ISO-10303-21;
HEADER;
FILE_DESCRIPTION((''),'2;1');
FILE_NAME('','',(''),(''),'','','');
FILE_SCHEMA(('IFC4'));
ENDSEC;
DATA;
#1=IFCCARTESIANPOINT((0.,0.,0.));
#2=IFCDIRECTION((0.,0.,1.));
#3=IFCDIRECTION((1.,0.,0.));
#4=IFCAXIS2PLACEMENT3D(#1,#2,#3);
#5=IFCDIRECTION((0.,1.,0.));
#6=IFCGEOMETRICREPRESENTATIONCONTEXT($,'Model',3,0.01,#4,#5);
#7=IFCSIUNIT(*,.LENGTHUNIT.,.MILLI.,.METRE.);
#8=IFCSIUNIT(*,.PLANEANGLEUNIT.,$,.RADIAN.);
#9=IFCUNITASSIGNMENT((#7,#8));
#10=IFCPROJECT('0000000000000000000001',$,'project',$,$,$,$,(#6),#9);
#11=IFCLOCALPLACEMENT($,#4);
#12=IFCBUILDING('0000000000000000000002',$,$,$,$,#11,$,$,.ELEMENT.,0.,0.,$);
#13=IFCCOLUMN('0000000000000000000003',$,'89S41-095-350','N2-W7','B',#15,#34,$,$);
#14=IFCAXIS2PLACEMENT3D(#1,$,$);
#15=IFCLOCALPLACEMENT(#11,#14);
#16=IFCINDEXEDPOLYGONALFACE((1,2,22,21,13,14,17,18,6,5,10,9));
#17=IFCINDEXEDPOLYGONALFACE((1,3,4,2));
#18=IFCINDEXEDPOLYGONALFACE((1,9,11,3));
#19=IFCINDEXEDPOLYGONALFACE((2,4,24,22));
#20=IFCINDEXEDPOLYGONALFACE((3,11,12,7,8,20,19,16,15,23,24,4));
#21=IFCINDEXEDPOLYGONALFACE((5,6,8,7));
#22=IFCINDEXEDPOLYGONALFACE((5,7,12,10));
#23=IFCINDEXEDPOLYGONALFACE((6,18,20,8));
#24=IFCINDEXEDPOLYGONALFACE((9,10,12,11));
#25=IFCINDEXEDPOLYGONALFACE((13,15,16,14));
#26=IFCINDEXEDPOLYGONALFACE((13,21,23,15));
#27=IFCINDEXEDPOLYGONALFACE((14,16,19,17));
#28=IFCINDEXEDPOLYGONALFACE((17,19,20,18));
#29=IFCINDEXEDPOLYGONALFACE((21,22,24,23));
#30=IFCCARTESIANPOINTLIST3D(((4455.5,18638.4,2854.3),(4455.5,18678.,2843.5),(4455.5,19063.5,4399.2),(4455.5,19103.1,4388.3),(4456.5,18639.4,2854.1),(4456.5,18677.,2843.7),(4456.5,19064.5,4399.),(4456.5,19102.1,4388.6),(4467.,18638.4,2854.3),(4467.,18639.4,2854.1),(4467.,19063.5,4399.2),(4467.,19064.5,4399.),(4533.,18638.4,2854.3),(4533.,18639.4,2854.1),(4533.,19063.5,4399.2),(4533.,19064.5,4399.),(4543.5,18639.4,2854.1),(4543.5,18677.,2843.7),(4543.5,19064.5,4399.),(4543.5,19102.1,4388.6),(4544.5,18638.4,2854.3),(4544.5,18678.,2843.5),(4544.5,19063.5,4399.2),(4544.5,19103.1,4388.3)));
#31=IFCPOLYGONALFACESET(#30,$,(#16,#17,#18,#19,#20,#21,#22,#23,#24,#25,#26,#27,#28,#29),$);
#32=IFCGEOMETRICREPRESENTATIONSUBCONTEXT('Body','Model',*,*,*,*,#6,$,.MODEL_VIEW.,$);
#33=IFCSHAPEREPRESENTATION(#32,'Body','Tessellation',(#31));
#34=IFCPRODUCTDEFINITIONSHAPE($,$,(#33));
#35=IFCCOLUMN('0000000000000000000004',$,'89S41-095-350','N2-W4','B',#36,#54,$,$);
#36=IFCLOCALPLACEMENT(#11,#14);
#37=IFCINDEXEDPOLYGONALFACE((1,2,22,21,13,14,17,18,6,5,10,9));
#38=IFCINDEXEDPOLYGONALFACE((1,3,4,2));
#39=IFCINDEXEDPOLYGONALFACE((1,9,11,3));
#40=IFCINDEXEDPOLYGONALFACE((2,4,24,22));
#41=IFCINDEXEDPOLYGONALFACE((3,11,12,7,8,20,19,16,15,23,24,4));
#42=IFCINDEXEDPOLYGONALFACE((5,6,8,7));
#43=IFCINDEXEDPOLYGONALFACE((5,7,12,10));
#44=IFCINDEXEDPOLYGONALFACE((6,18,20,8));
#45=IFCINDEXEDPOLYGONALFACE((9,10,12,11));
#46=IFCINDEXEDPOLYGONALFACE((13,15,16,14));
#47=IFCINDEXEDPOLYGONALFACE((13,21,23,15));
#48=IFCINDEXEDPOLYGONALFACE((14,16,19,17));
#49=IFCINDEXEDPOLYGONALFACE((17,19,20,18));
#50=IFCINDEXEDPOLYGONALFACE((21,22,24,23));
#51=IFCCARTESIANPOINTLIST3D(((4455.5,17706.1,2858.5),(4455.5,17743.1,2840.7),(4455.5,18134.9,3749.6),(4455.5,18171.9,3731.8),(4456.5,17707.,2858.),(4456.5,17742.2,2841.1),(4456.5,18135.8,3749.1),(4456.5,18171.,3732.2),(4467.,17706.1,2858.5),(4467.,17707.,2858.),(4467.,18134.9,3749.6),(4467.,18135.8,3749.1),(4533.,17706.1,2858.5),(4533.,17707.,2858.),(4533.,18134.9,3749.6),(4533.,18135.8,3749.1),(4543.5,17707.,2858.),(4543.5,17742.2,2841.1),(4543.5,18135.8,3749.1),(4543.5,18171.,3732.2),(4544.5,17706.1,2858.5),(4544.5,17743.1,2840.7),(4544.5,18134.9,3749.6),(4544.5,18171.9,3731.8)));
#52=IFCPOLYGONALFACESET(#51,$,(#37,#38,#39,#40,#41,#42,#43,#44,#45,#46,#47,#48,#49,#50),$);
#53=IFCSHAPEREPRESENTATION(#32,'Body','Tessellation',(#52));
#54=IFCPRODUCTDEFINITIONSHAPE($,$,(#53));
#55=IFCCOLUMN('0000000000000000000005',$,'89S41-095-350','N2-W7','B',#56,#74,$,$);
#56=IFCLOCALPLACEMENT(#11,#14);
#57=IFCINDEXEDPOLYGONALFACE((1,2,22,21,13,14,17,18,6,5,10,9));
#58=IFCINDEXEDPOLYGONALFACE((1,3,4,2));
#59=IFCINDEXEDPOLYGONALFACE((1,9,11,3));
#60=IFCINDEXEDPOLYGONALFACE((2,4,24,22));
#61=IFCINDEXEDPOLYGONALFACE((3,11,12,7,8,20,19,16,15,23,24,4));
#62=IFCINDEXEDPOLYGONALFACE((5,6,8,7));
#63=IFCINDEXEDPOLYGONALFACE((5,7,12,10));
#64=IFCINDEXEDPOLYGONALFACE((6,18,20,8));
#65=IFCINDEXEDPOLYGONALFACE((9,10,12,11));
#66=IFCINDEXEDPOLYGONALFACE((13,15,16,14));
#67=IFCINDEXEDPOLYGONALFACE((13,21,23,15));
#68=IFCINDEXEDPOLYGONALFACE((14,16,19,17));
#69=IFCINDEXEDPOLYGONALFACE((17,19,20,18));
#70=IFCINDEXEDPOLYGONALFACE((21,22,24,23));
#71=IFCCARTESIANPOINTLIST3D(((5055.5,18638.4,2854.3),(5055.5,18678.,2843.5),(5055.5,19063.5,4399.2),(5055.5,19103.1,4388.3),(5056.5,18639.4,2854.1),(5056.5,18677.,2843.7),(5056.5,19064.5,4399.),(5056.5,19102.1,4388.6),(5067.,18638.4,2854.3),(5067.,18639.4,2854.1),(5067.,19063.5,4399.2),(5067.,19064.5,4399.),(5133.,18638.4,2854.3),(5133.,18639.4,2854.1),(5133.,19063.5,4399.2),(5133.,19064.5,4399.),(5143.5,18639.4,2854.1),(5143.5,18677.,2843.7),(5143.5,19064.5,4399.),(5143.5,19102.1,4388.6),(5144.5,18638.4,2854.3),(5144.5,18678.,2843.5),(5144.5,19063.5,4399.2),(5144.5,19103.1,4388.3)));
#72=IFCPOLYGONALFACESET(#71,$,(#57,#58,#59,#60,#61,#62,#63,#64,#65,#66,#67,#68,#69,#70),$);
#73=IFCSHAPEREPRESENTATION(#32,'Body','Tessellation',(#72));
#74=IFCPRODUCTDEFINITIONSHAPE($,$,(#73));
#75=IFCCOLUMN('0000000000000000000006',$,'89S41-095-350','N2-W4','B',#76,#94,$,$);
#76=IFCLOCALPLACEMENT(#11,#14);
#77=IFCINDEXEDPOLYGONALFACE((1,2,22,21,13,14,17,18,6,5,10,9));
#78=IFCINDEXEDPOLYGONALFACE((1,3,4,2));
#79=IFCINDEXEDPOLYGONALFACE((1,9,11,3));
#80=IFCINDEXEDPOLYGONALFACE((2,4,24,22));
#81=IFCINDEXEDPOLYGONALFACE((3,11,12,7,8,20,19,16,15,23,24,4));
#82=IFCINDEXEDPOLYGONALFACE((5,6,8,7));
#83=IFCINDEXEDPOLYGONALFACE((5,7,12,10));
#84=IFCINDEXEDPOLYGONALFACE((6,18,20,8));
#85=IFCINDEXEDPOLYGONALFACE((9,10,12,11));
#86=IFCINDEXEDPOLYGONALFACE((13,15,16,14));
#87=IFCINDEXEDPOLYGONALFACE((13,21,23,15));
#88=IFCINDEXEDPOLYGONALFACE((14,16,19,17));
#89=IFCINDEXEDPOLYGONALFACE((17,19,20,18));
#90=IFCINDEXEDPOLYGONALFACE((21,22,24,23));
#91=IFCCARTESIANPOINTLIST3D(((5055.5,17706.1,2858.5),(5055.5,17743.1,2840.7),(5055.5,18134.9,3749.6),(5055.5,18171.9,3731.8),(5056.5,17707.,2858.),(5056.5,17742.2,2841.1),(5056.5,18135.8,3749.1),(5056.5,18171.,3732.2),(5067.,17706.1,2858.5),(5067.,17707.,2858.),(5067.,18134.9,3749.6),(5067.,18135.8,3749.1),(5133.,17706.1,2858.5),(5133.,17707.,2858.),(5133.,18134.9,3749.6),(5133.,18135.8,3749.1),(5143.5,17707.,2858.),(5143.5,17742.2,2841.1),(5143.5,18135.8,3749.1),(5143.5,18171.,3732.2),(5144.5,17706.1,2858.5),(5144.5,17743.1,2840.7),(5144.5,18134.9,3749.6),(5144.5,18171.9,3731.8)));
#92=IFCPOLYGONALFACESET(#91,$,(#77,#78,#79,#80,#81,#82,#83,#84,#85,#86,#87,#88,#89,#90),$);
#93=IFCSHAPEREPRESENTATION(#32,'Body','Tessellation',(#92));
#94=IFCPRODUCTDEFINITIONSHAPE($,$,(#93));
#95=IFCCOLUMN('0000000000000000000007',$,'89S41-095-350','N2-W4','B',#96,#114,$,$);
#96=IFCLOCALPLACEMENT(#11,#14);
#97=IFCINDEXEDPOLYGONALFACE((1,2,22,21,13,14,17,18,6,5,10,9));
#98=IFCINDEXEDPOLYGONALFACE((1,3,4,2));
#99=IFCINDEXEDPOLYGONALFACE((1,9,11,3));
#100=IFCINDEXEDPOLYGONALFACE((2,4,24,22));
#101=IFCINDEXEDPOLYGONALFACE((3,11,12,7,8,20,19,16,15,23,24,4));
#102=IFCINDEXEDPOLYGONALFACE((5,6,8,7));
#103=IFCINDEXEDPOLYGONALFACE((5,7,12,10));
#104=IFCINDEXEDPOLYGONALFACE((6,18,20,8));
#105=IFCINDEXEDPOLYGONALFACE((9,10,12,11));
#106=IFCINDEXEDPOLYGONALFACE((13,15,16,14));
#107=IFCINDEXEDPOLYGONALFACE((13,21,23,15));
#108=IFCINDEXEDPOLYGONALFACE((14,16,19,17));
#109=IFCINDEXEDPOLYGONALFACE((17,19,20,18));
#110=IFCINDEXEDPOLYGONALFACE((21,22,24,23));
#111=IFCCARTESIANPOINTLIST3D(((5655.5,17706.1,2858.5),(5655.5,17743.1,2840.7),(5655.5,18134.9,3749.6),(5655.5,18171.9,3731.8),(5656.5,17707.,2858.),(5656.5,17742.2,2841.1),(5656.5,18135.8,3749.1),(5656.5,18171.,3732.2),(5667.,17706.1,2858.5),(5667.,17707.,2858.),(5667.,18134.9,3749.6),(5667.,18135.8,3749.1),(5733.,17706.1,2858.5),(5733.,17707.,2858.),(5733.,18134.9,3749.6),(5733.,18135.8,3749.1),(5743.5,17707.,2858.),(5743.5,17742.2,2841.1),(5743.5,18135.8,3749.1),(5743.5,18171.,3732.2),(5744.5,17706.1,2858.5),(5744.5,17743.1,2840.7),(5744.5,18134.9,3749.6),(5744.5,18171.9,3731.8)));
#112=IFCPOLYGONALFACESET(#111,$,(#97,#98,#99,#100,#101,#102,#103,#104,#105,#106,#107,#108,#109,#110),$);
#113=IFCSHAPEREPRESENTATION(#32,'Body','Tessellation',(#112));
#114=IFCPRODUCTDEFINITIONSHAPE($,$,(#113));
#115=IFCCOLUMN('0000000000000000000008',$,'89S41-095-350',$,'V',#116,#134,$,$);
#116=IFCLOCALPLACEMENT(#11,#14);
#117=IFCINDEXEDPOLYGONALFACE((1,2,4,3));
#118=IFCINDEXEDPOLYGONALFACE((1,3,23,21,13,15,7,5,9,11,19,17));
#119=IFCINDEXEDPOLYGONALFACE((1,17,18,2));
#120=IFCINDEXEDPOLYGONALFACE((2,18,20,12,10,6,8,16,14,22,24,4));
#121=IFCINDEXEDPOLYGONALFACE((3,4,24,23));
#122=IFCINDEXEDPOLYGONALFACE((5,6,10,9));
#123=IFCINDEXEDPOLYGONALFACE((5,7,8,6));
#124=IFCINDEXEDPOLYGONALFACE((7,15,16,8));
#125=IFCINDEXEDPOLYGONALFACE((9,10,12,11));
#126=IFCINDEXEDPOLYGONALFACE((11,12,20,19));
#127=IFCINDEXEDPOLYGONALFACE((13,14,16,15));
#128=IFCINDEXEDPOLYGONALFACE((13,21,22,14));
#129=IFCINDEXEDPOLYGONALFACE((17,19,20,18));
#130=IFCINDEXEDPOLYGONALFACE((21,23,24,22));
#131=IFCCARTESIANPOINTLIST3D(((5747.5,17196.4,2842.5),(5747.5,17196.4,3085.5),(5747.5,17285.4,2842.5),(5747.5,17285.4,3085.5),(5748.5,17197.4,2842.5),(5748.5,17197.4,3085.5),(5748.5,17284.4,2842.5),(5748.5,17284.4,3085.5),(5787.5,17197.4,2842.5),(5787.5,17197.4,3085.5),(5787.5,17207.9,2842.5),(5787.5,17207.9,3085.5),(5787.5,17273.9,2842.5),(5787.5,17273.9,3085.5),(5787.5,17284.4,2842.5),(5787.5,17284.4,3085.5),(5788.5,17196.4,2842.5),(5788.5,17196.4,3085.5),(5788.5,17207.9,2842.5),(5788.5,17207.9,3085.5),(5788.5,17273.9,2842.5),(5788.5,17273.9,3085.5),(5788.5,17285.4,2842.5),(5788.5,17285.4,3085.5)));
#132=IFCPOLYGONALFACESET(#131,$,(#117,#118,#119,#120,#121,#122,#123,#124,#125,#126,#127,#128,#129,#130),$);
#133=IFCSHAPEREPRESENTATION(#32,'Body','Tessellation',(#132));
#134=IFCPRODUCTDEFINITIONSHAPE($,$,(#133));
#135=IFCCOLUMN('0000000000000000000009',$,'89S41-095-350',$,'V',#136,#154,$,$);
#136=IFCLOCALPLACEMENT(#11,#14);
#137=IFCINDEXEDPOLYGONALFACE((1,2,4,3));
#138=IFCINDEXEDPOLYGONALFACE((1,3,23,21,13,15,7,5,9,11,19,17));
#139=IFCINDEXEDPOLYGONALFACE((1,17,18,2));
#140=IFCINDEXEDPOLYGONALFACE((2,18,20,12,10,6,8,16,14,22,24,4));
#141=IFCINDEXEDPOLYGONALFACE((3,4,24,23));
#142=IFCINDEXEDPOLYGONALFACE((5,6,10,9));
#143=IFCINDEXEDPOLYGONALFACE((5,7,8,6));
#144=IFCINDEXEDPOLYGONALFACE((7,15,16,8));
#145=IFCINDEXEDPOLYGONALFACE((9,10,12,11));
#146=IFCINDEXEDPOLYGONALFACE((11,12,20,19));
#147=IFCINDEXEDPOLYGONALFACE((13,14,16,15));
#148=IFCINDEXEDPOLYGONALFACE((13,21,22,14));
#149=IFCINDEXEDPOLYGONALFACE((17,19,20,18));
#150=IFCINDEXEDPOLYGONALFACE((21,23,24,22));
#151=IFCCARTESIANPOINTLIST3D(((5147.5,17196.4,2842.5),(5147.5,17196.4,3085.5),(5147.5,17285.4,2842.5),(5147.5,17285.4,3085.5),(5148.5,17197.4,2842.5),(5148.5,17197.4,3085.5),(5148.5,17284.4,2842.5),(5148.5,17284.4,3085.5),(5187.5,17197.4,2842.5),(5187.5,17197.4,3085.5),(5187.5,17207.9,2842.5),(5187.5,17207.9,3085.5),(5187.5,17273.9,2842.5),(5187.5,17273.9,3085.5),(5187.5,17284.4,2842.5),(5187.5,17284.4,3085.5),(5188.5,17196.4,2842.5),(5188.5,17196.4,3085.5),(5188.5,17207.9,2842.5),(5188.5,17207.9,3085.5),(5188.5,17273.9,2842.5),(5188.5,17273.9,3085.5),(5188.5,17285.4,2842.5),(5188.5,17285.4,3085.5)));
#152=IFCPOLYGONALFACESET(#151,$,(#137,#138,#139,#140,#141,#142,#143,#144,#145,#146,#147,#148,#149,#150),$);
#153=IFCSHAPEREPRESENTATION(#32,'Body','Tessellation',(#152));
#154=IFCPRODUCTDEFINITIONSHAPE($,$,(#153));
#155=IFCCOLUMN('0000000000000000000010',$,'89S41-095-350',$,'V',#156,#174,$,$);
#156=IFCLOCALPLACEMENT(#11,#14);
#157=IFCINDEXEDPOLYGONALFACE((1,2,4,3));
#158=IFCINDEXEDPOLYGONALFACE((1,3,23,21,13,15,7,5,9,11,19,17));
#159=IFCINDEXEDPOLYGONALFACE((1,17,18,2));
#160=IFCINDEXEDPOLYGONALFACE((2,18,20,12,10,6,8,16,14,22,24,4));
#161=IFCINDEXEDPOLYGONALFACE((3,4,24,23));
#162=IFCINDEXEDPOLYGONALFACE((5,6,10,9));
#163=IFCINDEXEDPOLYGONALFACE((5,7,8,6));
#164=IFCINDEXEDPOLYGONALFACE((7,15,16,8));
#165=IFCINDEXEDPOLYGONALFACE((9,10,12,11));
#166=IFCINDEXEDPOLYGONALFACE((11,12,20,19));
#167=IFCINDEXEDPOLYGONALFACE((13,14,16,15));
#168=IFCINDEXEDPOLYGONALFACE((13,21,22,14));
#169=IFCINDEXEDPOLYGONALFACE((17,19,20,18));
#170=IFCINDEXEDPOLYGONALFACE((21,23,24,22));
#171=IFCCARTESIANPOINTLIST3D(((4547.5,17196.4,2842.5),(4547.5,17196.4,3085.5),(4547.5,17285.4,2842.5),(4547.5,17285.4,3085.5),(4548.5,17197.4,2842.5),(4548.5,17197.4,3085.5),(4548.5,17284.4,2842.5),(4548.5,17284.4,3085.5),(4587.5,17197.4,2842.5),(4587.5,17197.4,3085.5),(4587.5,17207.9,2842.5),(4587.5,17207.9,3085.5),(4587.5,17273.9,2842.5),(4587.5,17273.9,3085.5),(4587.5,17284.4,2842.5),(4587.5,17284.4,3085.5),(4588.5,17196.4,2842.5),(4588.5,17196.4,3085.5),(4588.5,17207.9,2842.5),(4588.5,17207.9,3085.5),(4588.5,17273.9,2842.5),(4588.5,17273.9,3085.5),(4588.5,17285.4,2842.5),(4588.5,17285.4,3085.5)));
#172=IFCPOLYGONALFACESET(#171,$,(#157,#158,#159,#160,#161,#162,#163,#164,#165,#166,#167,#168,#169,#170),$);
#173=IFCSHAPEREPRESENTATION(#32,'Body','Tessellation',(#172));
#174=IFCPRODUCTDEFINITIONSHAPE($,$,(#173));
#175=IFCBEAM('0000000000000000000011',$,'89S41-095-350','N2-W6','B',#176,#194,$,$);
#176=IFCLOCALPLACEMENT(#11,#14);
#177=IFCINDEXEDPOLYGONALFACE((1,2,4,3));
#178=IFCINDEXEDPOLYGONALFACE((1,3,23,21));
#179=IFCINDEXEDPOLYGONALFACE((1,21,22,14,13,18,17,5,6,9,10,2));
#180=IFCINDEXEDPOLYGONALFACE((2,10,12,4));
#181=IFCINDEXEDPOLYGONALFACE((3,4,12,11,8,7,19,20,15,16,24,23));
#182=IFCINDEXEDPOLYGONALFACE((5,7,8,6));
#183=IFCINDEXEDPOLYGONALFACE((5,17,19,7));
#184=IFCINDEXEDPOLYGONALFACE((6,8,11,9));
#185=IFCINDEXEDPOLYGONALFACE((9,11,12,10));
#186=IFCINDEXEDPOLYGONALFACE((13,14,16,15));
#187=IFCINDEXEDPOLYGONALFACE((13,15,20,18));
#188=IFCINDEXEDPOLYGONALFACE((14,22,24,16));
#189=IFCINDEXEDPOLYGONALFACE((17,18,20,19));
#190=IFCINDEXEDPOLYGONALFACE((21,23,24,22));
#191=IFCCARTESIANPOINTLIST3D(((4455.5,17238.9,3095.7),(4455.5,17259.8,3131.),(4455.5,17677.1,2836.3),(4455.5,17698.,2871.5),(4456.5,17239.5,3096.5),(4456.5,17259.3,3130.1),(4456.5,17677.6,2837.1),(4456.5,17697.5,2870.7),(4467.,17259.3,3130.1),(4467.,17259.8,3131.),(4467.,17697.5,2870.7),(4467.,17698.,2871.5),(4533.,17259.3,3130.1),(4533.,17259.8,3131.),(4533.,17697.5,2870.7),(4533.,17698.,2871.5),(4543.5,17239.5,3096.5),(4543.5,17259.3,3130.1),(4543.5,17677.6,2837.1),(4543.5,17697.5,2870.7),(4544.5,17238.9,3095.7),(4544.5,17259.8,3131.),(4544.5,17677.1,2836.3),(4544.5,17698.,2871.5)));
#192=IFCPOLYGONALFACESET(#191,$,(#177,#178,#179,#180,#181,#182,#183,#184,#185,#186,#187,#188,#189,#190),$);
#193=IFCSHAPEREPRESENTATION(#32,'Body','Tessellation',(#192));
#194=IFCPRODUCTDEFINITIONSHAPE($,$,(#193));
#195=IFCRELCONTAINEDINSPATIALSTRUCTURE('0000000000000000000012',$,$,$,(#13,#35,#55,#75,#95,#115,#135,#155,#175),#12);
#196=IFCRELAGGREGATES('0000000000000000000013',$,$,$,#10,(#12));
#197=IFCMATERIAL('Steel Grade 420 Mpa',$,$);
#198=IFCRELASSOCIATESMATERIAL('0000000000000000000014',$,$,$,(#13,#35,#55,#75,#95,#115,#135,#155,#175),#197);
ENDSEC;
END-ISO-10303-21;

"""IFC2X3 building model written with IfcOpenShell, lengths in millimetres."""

from ifc_helpers import new_model, si_unit, direction, frame, origin, origin_with_axes, origin_2d_with_axis, place, context, subcontext, project, spatial, c_section, extrude, source, transform, mapped, material, element, save


model = new_model("IFC2X3")

# Units and contexts
model_context = context("Model", 3, precision=0.01, world=origin_with_axes(), true_north=direction((0.0, 1.0, 0.0)))
body_context = subcontext(model_context, "Body", "Model", "MODEL_VIEW")
ifc_project = project(units=[si_unit("LENGTHUNIT", "METRE", prefix="MILLI"), si_unit("PLANEANGLEUNIT", "RADIAN")], contexts=[model_context])

# Building
building_placement = place(None, origin_with_axes())
building = spatial("IfcBuilding", under=ifc_project, at=building_placement, CompositionType="ELEMENT", ElevationOfRefHeight=0.0, ElevationOfTerrain=0.0)

# Columns
ifc_material = material(Name="Steel Grade 420 Mpa")
shared_shape_1 = source(origin(), body_context, "Body", "SweptSolid", [
    extrude(c_section(Depth=89.0, Width=41.0, WallThickness=1.0, Girth=11.5, at=origin_2d_with_axis()), origin_with_axes(), (0.0, 0.0, 1.0), 1602.3),
])
column_1_placement = place(None, frame((4500.0, 19083.3, 4393.8), z_axis=(0.0, -0.265305, -0.964165), x_axis=(0.0, -0.964165, 0.265305)))
element("IfcColumn", 1, at=column_1_placement, inside=building, material=ifc_material, Name="89S41-095-350", Description="N2-W7", ObjectType="B", context=body_context, shape_type="MappedRepresentation", body=[
    mapped(shared_shape_1, transform((0.0, 0.0, 0.0), scale=1.0)),
])
shared_shape_2 = source(origin(), body_context, "Body", "SweptSolid", [
    extrude(c_section(Depth=89.0, Width=41.0, WallThickness=1.0, Girth=11.5, at=origin_2d_with_axis()), origin_with_axes(), (0.0, 0.0, 1.0), 988.9),
])
column_2_placement = place(None, frame((4500.0, 18153.4, 3740.7), z_axis=(0.0, -0.433624, -0.901094), x_axis=(0.0, -0.901094, 0.433624)))
element("IfcColumn", 2, at=column_2_placement, inside=building, material=ifc_material, Name="89S41-095-350", Description="N2-W4", ObjectType="B", context=body_context, shape_type="MappedRepresentation", body=[
    mapped(shared_shape_2, transform((0.0, 0.0, 0.0), scale=1.0)),
])
shared_shape_3 = source(origin(), body_context, "Body", "SweptSolid", [
    extrude(c_section(Depth=89.0, Width=41.0, WallThickness=1.0, Girth=11.5, at=origin_2d_with_axis()), origin_with_axes(), (0.0, 0.0, 1.0), 1602.3),
])
column_3_placement = place(None, frame((5100.0, 19083.3, 4393.8), z_axis=(0.0, -0.265305, -0.964165), x_axis=(0.0, -0.964165, 0.265305)))
element("IfcColumn", 3, at=column_3_placement, inside=building, material=ifc_material, Name="89S41-095-350", Description="N2-W7", ObjectType="B", context=body_context, shape_type="MappedRepresentation", body=[
    mapped(shared_shape_3, transform((0.0, 0.0, 0.0), scale=1.0)),
])
shared_shape_4 = source(origin(), body_context, "Body", "SweptSolid", [
    extrude(c_section(Depth=89.0, Width=41.0, WallThickness=1.0, Girth=11.5, at=origin_2d_with_axis()), origin_with_axes(), (0.0, 0.0, 1.0), 988.9),
])
column_4_placement = place(None, frame((5100.0, 18153.4, 3740.7), z_axis=(0.0, -0.433624, -0.901094), x_axis=(0.0, -0.901094, 0.433624)))
element("IfcColumn", 4, at=column_4_placement, inside=building, material=ifc_material, Name="89S41-095-350", Description="N2-W4", ObjectType="B", context=body_context, shape_type="MappedRepresentation", body=[
    mapped(shared_shape_4, transform((0.0, 0.0, 0.0), scale=1.0)),
])
shared_shape_5 = source(origin(), body_context, "Body", "SweptSolid", [
    extrude(c_section(Depth=89.0, Width=41.0, WallThickness=1.0, Girth=11.5, at=origin_2d_with_axis()), origin_with_axes(), (0.0, 0.0, 1.0), 988.9),
])
column_5_placement = place(None, frame((5700.0, 18153.4, 3740.7), z_axis=(0.0, -0.433624, -0.901094), x_axis=(0.0, -0.901094, 0.433624)))
element("IfcColumn", 5, at=column_5_placement, inside=building, material=ifc_material, Name="89S41-095-350", Description="N2-W4", ObjectType="B", context=body_context, shape_type="MappedRepresentation", body=[
    mapped(shared_shape_5, transform((0.0, 0.0, 0.0), scale=1.0)),
])
shared_shape_6 = source(origin(), body_context, "Body", "SweptSolid", [
    extrude(c_section(Depth=89.0, Width=41.0, WallThickness=1.0, Girth=11.5, at=origin_2d_with_axis()), origin_with_axes(), (0.0, 0.0, 1.0), 243.0),
])
column_6_placement = place(None, frame((5768.0, 17240.9, 3085.5), z_axis=(0.0, 0.0, -1.0), x_axis=(1.0, 0.0, 0.0)))
element("IfcColumn", 6, at=column_6_placement, inside=building, material=ifc_material, Name="89S41-095-350", ObjectType="V", context=body_context, shape_type="MappedRepresentation", body=[
    mapped(shared_shape_6, transform((0.0, 0.0, 0.0), scale=1.0)),
])
shared_shape_7 = source(origin(), body_context, "Body", "SweptSolid", [
    extrude(c_section(Depth=89.0, Width=41.0, WallThickness=1.0, Girth=11.5, at=origin_2d_with_axis()), origin_with_axes(), (0.0, 0.0, 1.0), 243.0),
])
column_7_placement = place(None, frame((5168.0, 17240.9, 3085.5), z_axis=(0.0, 0.0, -1.0), x_axis=(1.0, 0.0, 0.0)))
element("IfcColumn", 7, at=column_7_placement, inside=building, material=ifc_material, Name="89S41-095-350", ObjectType="V", context=body_context, shape_type="MappedRepresentation", body=[
    mapped(shared_shape_7, transform((0.0, 0.0, 0.0), scale=1.0)),
])
shared_shape_8 = source(origin(), body_context, "Body", "SweptSolid", [
    extrude(c_section(Depth=89.0, Width=41.0, WallThickness=1.0, Girth=11.5, at=origin_2d_with_axis()), origin_with_axes(), (0.0, 0.0, 1.0), 243.0),
])
column_8_placement = place(None, frame((4568.0, 17240.9, 3085.5), z_axis=(0.0, 0.0, -1.0), x_axis=(1.0, 0.0, 0.0)))
element("IfcColumn", 8, at=column_8_placement, inside=building, material=ifc_material, Name="89S41-095-350", ObjectType="V", context=body_context, shape_type="MappedRepresentation", body=[
    mapped(shared_shape_8, transform((0.0, 0.0, 0.0), scale=1.0)),
])

# Beam
shared_shape_9 = source(origin(), body_context, "Body", "SweptSolid", [
    extrude(c_section(Depth=89.0, Width=41.0, WallThickness=1.0, Girth=11.5, at=origin_2d_with_axis()), origin_with_axes(), (0.0, 0.0, 1.0), 509.2),
])
beam_1_placement = place(None, frame((4500.0, 17687.6, 2853.9), z_axis=(0.0, -0.860497, 0.509455), x_axis=(0.0, 0.509455, 0.860497)))
element("IfcBeam", 9, at=beam_1_placement, inside=building, material=ifc_material, Name="89S41-095-350", Description="N2-W6", ObjectType="B", context=body_context, shape_type="MappedRepresentation", body=[
    mapped(shared_shape_9, transform((0.0, 0.0, 0.0), scale=1.0)),
])

save(model, "model.ifc")
